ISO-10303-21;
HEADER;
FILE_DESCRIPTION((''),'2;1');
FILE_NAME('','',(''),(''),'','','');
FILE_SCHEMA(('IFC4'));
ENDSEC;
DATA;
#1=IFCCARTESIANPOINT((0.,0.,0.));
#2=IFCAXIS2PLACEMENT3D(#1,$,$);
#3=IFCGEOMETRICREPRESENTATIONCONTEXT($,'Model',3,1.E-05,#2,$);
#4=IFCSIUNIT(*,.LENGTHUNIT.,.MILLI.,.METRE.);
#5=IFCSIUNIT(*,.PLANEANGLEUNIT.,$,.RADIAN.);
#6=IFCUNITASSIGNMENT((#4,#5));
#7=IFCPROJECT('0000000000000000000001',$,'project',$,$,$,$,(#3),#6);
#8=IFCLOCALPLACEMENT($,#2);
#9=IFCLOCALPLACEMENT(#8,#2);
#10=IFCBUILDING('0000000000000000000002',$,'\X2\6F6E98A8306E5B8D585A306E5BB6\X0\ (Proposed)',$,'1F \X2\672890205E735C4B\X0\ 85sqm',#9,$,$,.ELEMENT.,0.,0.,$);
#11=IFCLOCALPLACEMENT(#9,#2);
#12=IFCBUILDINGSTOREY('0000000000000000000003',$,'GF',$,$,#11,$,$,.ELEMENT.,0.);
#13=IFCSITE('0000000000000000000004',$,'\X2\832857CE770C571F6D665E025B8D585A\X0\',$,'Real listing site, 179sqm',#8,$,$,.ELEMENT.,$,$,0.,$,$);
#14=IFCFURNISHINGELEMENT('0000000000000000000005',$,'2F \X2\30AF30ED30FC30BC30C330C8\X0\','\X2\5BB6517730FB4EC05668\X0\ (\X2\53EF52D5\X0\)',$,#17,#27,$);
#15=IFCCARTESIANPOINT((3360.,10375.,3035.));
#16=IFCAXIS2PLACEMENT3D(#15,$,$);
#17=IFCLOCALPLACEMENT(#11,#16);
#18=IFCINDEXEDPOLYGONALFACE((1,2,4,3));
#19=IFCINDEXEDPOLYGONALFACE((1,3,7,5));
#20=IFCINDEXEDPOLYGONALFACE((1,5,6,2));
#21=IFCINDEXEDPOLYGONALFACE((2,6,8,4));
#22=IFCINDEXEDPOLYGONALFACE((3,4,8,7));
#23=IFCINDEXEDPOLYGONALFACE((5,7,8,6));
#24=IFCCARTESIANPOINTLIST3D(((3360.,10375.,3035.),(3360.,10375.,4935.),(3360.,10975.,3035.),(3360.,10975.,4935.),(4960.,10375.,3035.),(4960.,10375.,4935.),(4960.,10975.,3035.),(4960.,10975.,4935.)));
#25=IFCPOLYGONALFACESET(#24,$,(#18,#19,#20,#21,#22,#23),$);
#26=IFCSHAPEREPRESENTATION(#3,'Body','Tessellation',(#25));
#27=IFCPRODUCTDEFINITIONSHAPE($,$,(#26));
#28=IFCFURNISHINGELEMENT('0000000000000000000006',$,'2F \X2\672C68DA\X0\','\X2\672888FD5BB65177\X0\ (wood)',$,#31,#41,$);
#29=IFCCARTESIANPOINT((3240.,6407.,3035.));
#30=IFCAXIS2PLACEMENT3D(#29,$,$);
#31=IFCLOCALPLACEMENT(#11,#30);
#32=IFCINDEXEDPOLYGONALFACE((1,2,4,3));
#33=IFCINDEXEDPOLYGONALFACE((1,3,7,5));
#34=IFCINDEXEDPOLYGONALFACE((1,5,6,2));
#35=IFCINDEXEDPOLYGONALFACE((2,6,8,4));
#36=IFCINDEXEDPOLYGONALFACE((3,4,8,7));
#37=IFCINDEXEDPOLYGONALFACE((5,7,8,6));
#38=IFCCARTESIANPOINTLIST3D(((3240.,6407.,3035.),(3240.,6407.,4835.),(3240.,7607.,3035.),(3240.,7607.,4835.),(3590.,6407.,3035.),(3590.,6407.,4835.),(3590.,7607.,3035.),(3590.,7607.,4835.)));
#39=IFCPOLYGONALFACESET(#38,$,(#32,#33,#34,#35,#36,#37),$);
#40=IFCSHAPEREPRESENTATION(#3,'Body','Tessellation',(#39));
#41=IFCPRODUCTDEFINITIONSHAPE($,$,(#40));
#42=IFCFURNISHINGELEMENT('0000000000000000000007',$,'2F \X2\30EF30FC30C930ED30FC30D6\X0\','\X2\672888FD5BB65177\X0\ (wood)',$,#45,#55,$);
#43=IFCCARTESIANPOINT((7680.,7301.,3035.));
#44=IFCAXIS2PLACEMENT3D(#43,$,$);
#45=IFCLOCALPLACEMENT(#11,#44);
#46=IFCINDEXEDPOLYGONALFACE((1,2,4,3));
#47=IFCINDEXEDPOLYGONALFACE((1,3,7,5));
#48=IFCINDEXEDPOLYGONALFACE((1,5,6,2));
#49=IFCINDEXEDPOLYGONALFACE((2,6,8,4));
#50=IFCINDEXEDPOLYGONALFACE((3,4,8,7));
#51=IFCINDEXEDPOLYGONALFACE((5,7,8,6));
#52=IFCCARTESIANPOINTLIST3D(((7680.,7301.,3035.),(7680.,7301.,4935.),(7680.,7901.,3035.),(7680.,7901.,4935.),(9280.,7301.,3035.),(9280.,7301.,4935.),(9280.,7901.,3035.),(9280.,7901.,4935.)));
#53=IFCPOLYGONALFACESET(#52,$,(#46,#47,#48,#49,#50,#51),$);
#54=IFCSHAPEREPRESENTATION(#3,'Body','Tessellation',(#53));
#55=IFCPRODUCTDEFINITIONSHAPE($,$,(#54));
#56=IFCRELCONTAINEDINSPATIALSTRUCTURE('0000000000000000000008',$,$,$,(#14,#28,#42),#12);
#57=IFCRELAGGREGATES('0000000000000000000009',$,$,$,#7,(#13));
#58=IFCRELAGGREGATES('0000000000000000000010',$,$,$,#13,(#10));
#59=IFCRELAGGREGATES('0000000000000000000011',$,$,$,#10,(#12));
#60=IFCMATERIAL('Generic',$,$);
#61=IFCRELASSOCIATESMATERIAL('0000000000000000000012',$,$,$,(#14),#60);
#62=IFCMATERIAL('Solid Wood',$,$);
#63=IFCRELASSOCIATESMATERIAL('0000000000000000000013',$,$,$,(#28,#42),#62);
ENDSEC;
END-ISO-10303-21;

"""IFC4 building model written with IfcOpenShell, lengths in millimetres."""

from ifc_helpers import new_model, si_unit, frame, frame_2d, origin, place, context, project, spatial, rectangle, extrude, material, element, save


model = new_model("IFC4")

# Units and contexts
model_context = context("Model", 3, precision=1e-05, world=origin())
ifc_project = project(units=[si_unit("LENGTHUNIT", "METRE", prefix="MILLI"), si_unit("PLANEANGLEUNIT", "RADIAN")], contexts=[model_context])

# Site, building, storey
site_placement = place(None, origin())
site = spatial("IfcSite", under=ifc_project, at=site_placement, Name="茨城県土浦市宍塚", ObjectType="Real listing site, 179sqm", CompositionType="ELEMENT", RefElevation=0.0)
building_placement = place(site_placement, origin())
building = spatial("IfcBuilding", under=site, at=building_placement, Name="潮風の宍塚の家 (Proposed)", ObjectType="1F 木造平屋 85sqm", CompositionType="ELEMENT", ElevationOfRefHeight=0.0, ElevationOfTerrain=0.0)
storey_placement = place(building_placement, origin())
storey = spatial("IfcBuildingStorey", under=building, at=storey_placement, Name="GF", CompositionType="ELEMENT", Elevation=0.0)

# Shared definitions
ifc_material_1 = material(Name="Solid Wood")

# Shared definitions
ifc_material_2 = material(Name="Generic")

# Furnishing elements
furnishing_1_placement = place(storey_placement, frame((3360.0, 10375.0, 3035.0)))
element("IfcFurnishingElement", 1, at=furnishing_1_placement, inside=storey, material=ifc_material_2, Name="2F クローゼット", Description="家具・什器 (可動)", context=model_context, shape_type="SweptSolid", body=[
    extrude(rectangle(XDim=1600.0, YDim=600.0, at=frame_2d((800.0, 300.0))), frame((3360.0, 10375.0, 3035.0)), (0.0, 0.0, 1.0), 1900.0),
])
furnishing_2_placement = place(storey_placement, frame((3240.0, 6407.0, 3035.0)))
element("IfcFurnishingElement", 2, at=furnishing_2_placement, inside=storey, material=ifc_material_1, Name="2F 本棚", Description="木製家具 (wood)", context=model_context, shape_type="SweptSolid", body=[
    extrude(rectangle(XDim=350.0, YDim=1200.0, at=frame_2d((175.0, 600.0))), frame((3240.0, 6407.0, 3035.0)), (0.0, 0.0, 1.0), 1800.0),
])
furnishing_3_placement = place(storey_placement, frame((7680.0, 7301.0, 3035.0)))
element("IfcFurnishingElement", 3, at=furnishing_3_placement, inside=storey, material=ifc_material_1, Name="2F ワードローブ", Description="木製家具 (wood)", context=model_context, shape_type="SweptSolid", body=[
    extrude(rectangle(XDim=1600.0, YDim=600.0, at=frame_2d((800.0, 300.0))), frame((7680.0, 7301.0, 3035.0)), (0.0, 0.0, 1.0), 1900.0),
])

save(model, "model.ifc")
